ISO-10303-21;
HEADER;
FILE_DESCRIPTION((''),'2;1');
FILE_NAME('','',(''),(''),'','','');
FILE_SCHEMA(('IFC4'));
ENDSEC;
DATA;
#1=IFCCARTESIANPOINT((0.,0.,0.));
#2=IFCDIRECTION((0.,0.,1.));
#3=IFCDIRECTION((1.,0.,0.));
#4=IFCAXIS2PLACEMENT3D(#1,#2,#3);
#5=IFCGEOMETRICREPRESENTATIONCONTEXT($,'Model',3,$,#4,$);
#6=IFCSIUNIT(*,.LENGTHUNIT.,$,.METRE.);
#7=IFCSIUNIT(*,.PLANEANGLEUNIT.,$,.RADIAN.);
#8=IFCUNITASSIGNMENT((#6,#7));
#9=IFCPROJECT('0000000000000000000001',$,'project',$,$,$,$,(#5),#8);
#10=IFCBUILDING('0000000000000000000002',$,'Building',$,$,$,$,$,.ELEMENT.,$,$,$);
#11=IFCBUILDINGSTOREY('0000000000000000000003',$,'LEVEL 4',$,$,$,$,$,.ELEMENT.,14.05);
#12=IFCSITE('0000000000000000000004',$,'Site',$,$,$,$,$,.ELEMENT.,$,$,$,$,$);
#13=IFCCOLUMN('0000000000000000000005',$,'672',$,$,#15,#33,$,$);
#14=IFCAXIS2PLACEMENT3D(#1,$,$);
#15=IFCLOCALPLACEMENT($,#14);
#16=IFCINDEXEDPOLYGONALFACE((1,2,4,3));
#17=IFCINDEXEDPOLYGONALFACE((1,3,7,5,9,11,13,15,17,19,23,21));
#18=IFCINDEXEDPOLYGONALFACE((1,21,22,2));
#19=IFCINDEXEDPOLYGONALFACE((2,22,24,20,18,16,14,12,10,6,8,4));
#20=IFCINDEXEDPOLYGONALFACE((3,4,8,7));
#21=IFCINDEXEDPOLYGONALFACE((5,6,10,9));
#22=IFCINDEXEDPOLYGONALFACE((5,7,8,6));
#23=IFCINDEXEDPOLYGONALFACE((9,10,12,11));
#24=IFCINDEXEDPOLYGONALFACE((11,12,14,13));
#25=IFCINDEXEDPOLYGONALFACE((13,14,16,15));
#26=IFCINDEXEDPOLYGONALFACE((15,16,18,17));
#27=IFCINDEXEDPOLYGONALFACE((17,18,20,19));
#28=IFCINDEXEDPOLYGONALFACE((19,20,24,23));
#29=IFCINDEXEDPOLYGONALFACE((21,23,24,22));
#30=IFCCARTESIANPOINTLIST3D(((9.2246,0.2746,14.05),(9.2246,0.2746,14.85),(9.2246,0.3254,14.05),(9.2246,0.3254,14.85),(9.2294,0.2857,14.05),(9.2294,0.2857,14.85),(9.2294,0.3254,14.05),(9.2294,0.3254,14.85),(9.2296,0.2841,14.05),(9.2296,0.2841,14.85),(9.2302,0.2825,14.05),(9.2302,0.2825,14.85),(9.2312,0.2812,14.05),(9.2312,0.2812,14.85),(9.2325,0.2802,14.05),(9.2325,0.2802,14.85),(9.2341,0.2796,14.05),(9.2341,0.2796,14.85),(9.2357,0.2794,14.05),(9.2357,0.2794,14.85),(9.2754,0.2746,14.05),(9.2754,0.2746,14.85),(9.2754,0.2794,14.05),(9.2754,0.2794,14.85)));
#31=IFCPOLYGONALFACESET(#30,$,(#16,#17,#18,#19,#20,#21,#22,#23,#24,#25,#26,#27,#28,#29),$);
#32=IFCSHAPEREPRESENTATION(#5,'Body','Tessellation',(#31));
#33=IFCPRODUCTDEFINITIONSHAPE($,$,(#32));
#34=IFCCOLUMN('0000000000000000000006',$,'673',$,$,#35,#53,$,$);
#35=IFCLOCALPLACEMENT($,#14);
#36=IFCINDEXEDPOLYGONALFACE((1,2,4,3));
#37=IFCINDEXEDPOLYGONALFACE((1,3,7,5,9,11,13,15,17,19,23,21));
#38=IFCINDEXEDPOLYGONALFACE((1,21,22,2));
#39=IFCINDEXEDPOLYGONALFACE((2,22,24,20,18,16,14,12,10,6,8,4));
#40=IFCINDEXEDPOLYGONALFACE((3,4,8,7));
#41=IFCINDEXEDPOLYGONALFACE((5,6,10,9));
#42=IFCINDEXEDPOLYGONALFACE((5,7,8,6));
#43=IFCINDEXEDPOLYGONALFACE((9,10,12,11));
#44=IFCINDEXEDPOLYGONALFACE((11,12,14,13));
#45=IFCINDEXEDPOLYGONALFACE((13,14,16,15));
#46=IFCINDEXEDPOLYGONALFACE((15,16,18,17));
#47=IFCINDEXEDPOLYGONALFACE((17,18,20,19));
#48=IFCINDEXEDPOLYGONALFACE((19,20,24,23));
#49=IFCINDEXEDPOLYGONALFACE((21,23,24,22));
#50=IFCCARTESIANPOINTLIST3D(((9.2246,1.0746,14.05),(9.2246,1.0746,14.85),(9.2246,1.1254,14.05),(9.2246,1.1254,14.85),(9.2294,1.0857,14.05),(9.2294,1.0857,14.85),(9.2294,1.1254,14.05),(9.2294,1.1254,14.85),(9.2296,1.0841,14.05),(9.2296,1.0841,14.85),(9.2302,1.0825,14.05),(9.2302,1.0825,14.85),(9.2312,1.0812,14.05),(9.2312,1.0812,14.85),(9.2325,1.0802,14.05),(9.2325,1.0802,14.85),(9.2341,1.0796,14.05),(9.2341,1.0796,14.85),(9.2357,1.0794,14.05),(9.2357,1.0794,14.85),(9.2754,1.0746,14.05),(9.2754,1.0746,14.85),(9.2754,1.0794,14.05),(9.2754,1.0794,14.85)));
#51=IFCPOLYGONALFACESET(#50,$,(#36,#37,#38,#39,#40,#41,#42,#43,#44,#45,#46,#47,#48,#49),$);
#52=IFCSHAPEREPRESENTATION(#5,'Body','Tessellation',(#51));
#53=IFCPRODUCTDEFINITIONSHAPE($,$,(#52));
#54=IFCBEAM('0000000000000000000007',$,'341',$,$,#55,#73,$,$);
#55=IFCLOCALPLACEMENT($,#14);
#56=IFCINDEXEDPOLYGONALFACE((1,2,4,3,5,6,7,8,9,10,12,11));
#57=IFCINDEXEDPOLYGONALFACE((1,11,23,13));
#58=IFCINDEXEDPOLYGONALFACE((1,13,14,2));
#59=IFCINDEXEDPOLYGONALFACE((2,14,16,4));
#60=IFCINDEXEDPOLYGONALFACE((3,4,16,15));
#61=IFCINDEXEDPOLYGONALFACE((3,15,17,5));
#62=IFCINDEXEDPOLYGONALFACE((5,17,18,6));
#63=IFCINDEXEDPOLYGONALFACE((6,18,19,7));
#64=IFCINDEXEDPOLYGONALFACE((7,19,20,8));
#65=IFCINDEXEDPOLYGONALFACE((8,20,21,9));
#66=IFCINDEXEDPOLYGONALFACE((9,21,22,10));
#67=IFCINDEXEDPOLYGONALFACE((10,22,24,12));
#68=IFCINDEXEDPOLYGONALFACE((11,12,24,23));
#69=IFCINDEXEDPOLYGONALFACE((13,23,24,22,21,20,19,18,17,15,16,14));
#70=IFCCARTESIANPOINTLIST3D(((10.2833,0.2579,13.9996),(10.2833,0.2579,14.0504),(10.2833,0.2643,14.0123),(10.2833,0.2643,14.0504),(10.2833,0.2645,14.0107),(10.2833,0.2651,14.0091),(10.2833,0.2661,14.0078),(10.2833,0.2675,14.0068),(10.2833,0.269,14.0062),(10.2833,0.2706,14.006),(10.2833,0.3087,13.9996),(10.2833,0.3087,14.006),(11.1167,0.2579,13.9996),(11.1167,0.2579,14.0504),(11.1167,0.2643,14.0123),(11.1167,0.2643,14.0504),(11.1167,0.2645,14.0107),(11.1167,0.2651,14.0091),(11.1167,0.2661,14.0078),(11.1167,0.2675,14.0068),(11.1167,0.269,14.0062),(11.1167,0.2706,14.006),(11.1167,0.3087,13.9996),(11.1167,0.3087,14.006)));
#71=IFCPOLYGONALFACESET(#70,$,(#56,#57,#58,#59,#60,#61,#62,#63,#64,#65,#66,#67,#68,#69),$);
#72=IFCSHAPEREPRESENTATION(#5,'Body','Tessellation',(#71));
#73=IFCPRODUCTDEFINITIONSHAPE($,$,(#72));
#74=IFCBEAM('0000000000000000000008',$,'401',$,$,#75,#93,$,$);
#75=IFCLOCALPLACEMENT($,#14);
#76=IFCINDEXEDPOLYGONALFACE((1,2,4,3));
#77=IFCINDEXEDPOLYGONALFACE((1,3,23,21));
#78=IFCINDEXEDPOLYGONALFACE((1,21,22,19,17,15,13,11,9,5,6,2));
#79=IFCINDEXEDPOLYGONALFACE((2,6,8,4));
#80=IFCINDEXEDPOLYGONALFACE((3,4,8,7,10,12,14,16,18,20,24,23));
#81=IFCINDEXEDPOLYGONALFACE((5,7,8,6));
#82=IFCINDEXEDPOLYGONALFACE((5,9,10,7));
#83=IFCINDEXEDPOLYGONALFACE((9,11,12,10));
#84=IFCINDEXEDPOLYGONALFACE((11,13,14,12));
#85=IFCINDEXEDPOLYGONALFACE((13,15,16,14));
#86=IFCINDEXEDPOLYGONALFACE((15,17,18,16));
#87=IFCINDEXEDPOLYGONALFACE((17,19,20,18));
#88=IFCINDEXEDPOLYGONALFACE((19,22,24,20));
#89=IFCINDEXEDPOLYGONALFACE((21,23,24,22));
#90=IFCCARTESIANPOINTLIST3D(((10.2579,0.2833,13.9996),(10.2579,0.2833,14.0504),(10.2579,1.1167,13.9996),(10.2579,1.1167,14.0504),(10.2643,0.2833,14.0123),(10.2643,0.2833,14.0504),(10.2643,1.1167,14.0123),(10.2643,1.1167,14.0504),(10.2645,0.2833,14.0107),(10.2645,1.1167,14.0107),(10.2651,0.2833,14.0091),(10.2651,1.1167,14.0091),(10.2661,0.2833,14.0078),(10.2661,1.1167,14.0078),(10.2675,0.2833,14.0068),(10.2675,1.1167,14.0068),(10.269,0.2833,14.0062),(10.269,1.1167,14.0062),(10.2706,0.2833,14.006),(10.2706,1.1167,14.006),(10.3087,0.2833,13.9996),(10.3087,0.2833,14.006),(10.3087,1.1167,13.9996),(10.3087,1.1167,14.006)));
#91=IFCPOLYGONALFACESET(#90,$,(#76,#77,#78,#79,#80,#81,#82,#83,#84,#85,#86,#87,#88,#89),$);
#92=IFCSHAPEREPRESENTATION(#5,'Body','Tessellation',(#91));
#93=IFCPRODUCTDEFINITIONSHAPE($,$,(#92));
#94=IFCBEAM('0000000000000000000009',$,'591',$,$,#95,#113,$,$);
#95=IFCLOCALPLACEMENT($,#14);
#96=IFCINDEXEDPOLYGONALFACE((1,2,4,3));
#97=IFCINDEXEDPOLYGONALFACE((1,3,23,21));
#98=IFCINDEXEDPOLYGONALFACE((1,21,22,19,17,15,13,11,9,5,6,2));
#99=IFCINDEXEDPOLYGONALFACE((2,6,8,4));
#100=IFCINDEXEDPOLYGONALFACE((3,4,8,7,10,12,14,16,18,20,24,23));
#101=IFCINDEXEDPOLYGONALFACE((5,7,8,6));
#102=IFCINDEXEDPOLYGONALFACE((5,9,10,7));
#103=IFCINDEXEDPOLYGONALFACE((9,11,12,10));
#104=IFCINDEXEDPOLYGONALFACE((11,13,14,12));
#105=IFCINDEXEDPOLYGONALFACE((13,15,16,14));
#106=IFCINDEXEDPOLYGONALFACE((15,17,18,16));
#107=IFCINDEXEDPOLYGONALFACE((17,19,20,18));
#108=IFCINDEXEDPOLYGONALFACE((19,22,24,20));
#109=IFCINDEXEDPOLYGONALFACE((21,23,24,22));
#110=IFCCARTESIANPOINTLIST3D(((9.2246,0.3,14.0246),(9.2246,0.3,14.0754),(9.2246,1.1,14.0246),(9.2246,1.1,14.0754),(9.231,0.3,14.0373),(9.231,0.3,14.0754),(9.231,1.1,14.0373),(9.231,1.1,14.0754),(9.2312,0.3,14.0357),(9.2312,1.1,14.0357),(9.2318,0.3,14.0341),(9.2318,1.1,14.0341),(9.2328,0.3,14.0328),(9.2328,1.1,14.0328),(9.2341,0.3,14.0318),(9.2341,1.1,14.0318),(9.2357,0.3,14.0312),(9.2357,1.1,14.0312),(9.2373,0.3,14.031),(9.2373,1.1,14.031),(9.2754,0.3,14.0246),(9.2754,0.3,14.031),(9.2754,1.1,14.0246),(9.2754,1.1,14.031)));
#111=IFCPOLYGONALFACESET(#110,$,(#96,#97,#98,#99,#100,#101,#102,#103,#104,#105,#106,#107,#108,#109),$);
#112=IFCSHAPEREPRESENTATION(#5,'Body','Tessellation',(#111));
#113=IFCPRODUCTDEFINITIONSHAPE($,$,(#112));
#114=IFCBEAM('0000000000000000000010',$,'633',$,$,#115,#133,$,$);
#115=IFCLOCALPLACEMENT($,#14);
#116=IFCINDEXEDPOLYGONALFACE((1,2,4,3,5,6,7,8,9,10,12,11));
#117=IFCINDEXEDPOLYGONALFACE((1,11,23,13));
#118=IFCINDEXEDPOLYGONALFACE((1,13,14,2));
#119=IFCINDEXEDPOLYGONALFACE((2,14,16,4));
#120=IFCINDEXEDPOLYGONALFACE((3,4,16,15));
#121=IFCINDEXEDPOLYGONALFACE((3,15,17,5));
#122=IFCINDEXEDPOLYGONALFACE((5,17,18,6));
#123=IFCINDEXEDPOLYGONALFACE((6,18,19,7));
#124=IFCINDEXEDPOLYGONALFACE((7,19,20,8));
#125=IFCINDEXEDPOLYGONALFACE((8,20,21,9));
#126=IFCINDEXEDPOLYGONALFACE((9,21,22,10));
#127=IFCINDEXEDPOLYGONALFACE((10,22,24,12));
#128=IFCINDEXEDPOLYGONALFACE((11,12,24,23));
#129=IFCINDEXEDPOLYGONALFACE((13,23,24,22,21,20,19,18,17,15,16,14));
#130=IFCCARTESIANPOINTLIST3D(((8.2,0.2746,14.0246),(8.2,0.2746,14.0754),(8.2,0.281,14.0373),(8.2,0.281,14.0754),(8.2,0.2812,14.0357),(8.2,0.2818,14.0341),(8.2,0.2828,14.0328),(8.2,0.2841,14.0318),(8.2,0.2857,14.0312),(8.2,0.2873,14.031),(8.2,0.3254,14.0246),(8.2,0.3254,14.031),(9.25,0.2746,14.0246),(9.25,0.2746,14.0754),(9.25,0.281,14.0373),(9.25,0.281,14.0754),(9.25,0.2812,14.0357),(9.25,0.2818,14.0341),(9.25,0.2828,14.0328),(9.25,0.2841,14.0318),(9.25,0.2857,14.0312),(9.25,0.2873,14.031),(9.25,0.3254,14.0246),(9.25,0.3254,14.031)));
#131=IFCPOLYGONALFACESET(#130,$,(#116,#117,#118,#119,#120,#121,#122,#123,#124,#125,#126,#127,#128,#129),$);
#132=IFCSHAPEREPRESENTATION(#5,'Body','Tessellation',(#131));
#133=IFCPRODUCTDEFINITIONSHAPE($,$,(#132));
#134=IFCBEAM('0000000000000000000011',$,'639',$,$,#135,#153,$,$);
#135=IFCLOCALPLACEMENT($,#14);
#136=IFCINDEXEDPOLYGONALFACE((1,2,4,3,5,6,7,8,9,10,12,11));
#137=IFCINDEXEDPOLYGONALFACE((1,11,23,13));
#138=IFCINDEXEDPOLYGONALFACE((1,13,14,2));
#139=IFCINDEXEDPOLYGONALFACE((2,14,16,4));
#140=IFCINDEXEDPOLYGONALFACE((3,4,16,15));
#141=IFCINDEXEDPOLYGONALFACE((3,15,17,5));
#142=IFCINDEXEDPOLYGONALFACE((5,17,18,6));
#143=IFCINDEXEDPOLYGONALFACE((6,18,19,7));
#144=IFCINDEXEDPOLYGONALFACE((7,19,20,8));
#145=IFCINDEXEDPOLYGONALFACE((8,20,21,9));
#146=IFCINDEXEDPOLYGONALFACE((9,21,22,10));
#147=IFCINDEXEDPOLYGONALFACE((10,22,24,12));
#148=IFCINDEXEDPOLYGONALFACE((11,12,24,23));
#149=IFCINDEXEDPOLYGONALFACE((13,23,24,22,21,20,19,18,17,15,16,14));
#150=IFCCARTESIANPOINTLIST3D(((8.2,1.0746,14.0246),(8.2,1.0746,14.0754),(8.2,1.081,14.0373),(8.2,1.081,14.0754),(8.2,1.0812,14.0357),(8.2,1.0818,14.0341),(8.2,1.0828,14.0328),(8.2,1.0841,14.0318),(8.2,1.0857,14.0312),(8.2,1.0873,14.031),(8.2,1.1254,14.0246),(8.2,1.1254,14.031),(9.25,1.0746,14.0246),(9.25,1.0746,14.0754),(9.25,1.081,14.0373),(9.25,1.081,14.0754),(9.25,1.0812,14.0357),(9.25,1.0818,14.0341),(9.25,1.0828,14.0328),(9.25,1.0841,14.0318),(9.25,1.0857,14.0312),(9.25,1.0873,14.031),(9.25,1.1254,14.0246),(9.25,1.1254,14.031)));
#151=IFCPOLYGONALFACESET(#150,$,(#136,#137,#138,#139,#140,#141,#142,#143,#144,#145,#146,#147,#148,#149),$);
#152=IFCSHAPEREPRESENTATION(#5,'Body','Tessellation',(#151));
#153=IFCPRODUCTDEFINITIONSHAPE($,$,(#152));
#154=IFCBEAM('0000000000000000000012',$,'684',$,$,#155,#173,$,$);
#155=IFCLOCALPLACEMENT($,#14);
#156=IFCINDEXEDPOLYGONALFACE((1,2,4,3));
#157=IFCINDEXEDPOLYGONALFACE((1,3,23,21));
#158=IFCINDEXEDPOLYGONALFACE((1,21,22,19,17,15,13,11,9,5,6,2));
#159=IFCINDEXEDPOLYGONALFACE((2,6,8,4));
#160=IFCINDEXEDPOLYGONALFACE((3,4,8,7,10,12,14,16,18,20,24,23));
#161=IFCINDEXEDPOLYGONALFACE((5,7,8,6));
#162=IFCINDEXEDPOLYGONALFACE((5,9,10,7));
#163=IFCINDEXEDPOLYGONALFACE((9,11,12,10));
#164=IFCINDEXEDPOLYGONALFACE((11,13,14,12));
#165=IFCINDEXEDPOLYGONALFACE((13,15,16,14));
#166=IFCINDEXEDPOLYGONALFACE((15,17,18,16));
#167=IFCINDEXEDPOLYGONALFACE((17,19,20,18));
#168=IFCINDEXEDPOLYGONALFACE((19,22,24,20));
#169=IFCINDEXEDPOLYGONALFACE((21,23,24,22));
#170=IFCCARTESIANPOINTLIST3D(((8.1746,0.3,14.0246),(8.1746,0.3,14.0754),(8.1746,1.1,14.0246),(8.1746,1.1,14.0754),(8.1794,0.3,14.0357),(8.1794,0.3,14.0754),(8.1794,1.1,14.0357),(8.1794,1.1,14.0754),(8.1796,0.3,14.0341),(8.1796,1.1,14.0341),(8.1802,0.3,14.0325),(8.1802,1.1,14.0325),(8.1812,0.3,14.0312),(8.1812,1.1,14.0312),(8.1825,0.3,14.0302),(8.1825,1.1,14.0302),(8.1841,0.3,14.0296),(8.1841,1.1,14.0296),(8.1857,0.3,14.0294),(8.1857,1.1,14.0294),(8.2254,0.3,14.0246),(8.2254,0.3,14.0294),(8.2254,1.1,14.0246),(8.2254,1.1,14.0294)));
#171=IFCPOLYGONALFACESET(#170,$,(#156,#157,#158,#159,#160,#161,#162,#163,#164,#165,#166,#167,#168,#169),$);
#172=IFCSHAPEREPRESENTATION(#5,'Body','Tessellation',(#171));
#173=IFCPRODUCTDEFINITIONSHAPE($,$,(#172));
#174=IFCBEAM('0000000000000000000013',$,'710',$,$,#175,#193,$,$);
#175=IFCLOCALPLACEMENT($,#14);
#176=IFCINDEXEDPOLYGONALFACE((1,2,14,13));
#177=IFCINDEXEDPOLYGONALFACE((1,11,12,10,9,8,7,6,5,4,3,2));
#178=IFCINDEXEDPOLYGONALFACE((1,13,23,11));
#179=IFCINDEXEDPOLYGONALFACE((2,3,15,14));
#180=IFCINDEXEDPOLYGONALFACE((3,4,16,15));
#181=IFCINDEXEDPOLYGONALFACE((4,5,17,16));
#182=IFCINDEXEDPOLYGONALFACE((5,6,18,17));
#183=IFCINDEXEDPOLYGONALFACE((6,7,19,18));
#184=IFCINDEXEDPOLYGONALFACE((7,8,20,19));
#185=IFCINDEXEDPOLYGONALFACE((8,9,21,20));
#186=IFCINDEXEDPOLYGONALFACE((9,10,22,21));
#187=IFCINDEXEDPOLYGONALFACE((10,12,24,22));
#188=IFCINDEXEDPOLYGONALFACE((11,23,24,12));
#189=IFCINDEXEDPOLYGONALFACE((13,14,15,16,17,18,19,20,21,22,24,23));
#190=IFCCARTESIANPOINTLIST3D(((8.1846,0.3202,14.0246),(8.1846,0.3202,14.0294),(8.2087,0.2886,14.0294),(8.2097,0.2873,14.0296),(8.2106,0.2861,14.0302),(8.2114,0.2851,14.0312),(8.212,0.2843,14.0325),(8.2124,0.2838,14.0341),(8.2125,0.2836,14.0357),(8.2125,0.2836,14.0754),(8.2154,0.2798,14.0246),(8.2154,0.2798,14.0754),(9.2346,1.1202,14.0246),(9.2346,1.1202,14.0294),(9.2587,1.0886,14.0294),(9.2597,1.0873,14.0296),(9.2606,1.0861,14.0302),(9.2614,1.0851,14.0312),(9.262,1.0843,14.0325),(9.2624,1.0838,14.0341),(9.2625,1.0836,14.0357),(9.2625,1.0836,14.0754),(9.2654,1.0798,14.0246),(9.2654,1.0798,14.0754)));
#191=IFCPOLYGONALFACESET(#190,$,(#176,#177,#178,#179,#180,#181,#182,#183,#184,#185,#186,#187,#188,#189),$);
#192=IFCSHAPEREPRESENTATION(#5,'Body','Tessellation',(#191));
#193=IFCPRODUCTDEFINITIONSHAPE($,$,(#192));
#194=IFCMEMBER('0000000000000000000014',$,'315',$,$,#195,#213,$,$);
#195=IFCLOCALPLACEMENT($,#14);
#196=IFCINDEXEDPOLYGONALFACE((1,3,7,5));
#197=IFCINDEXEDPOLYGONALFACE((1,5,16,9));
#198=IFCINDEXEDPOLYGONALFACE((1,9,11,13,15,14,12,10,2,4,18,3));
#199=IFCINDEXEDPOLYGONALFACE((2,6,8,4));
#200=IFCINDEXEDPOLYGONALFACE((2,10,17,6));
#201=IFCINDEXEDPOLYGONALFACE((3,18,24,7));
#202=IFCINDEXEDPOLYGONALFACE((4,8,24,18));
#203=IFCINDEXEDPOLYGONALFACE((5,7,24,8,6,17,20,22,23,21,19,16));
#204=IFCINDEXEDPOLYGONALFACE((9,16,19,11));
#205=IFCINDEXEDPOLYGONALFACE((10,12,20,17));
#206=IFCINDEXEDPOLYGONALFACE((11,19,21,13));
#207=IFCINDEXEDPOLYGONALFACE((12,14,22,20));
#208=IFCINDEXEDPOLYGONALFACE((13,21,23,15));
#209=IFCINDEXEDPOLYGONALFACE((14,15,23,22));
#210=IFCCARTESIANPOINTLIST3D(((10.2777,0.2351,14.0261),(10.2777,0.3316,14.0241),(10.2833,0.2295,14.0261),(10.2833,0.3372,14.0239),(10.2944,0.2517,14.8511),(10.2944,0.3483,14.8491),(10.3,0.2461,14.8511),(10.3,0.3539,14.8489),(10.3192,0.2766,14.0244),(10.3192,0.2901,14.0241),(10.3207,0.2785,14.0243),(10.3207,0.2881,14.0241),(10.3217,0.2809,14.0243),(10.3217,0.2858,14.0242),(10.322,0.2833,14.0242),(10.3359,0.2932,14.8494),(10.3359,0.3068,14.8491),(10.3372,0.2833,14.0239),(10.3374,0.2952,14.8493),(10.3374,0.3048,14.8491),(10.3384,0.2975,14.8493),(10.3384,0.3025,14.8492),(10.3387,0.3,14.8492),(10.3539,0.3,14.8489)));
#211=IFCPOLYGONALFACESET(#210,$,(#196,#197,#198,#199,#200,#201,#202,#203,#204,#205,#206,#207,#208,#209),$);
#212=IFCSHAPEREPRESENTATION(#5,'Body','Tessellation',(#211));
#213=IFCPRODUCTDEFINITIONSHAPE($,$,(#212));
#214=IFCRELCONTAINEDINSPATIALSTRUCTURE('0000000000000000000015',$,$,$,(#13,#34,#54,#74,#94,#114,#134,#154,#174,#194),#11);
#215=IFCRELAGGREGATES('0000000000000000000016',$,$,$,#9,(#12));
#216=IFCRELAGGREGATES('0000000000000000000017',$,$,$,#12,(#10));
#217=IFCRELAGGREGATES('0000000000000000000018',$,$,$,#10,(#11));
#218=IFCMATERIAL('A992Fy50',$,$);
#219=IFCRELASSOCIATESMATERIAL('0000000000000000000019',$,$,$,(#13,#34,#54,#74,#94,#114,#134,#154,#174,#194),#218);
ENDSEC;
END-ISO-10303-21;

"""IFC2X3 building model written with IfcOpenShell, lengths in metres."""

from ifc_helpers import new_model, si_unit, frame, origin_with_axes, origin_2d_with_axis, place, context, project, spatial, l_section, extrude, material, element, save


model = new_model("IFC2X3")

# Units and contexts
model_context = context("Model", 3, world=origin_with_axes())
ifc_project = project(units=[si_unit("LENGTHUNIT", "METRE"), si_unit("PLANEANGLEUNIT", "RADIAN")], contexts=[model_context])

# Site, building, storey
site = spatial("IfcSite", under=ifc_project, Name="Site", CompositionType="ELEMENT")
building = spatial("IfcBuilding", under=site, Name="Building", CompositionType="ELEMENT")
storey = spatial("IfcBuildingStorey", under=building, Name="LEVEL 4", CompositionType="ELEMENT", Elevation=14.05)

# Columns
ifc_material = material(Name="A992Fy50")
for number, where, z_axis, x_axis, name in (
    (1, (9.25, 0.3, 14.85), (0.0, 0.0, -1.0), (0.0, 1.0, 0.0), "672"),
    (2, (9.25, 1.1, 14.85), (0.0, 0.0, -1.0), (0.0, 1.0, 0.0), "673"),
):
    element("IfcColumn", number, at=place(None, frame(where, z_axis=z_axis, x_axis=x_axis)), inside=storey, material=ifc_material, Name=name, context=model_context, shape_type="SweptSolid", body=[
        extrude(l_section(Depth=0.0508, Width=0.0508, Thickness=0.0048, FilletRadius=0.0063, at=origin_2d_with_axis()), origin_with_axes(), (0.0, 0.0, 1.0), 0.8),
    ])

# Beams
for number, where, z_axis, x_axis, name in (
    (3, (10.2833, 0.2833, 14.025), (1.0, 0.0, 0.0), (0.0, 1.0, 0.0), "341"),
    (4, (10.2833, 1.1167, 14.025), (0.0, -1.0, 0.0), (1.0, 0.0, 0.0), "401"),
):
    element("IfcBeam", number, at=place(None, frame(where, z_axis=z_axis, x_axis=x_axis)), inside=storey, material=ifc_material, Name=name, context=model_context, shape_type="SweptSolid", body=[
        extrude(l_section(Depth=0.0508, Width=0.0508, Thickness=0.0063, FilletRadius=0.0063, at=origin_2d_with_axis()), origin_with_axes(), (0.0, 0.0, 1.0), 0.8333),
    ])
beam_1_placement = place(None, frame((9.25, 1.1, 14.05), z_axis=(0.0, -1.0, 0.0), x_axis=(1.0, 0.0, 0.0)))
element("IfcBeam", 5, at=beam_1_placement, inside=storey, material=ifc_material, Name="591", context=model_context, shape_type="SweptSolid", body=[
    extrude(l_section(Depth=0.0508, Width=0.0508, Thickness=0.0063, FilletRadius=0.0063, at=origin_2d_with_axis()), origin_with_axes(), (0.0, 0.0, 1.0), 0.8),
])
for number, where, z_axis, x_axis, name in (
    (6, (8.2, 0.3, 14.05), (1.0, 0.0, 0.0), (0.0, 1.0, 0.0), "633"),
    (7, (8.2, 1.1, 14.05), (1.0, 0.0, 0.0), (0.0, 1.0, 0.0), "639"),
):
    element("IfcBeam", number, at=place(None, frame(where, z_axis=z_axis, x_axis=x_axis)), inside=storey, material=ifc_material, Name=name, context=model_context, shape_type="SweptSolid", body=[
        extrude(l_section(Depth=0.0508, Width=0.0508, Thickness=0.0063, FilletRadius=0.0063, at=origin_2d_with_axis()), origin_with_axes(), (0.0, 0.0, 1.0), 1.05),
    ])
beam_2_placement = place(None, frame((8.2, 1.1, 14.05), z_axis=(0.0, -1.0, 0.0), x_axis=(1.0, 0.0, 0.0)))
element("IfcBeam", 8, at=beam_2_placement, inside=storey, material=ifc_material, Name="684", context=model_context, shape_type="SweptSolid", body=[
    extrude(l_section(Depth=0.0508, Width=0.0508, Thickness=0.0048, FilletRadius=0.0063, at=origin_2d_with_axis()), origin_with_axes(), (0.0, 0.0, 1.0), 0.8),
])
beam_3_placement = place(None, frame((8.2, 0.3, 14.05), z_axis=(0.795432, 0.606043, 0.0), x_axis=(-0.606043, 0.795432, 0.0)))
element("IfcBeam", 9, at=beam_3_placement, inside=storey, material=ifc_material, Name="710", context=model_context, shape_type="SweptSolid", body=[
    extrude(l_section(Depth=0.0508, Width=0.0508, Thickness=0.0048, FilletRadius=0.0063, at=origin_2d_with_axis()), origin_with_axes(), (0.0, 0.0, 1.0), 1.32),
])

# Member
for number, where, z_axis, x_axis, name in (
    (10, (10.2833, 0.2833, 14.025), (0.020194, 0.020194, 0.999592), (-0.707107, 0.707107, 0.0), "315"),
):
    element("IfcMember", number, at=place(None, frame(where, z_axis=z_axis, x_axis=x_axis)), inside=storey, material=ifc_material, Name=name, context=model_context, shape_type="SweptSolid", body=[
        extrude(l_section(Depth=0.0762, Width=0.0762, Thickness=0.0079, FilletRadius=0.0096, at=origin_2d_with_axis()), origin_with_axes(), (0.0, 0.0, 1.0), 0.8253),
    ])

save(model, "model.ifc")
